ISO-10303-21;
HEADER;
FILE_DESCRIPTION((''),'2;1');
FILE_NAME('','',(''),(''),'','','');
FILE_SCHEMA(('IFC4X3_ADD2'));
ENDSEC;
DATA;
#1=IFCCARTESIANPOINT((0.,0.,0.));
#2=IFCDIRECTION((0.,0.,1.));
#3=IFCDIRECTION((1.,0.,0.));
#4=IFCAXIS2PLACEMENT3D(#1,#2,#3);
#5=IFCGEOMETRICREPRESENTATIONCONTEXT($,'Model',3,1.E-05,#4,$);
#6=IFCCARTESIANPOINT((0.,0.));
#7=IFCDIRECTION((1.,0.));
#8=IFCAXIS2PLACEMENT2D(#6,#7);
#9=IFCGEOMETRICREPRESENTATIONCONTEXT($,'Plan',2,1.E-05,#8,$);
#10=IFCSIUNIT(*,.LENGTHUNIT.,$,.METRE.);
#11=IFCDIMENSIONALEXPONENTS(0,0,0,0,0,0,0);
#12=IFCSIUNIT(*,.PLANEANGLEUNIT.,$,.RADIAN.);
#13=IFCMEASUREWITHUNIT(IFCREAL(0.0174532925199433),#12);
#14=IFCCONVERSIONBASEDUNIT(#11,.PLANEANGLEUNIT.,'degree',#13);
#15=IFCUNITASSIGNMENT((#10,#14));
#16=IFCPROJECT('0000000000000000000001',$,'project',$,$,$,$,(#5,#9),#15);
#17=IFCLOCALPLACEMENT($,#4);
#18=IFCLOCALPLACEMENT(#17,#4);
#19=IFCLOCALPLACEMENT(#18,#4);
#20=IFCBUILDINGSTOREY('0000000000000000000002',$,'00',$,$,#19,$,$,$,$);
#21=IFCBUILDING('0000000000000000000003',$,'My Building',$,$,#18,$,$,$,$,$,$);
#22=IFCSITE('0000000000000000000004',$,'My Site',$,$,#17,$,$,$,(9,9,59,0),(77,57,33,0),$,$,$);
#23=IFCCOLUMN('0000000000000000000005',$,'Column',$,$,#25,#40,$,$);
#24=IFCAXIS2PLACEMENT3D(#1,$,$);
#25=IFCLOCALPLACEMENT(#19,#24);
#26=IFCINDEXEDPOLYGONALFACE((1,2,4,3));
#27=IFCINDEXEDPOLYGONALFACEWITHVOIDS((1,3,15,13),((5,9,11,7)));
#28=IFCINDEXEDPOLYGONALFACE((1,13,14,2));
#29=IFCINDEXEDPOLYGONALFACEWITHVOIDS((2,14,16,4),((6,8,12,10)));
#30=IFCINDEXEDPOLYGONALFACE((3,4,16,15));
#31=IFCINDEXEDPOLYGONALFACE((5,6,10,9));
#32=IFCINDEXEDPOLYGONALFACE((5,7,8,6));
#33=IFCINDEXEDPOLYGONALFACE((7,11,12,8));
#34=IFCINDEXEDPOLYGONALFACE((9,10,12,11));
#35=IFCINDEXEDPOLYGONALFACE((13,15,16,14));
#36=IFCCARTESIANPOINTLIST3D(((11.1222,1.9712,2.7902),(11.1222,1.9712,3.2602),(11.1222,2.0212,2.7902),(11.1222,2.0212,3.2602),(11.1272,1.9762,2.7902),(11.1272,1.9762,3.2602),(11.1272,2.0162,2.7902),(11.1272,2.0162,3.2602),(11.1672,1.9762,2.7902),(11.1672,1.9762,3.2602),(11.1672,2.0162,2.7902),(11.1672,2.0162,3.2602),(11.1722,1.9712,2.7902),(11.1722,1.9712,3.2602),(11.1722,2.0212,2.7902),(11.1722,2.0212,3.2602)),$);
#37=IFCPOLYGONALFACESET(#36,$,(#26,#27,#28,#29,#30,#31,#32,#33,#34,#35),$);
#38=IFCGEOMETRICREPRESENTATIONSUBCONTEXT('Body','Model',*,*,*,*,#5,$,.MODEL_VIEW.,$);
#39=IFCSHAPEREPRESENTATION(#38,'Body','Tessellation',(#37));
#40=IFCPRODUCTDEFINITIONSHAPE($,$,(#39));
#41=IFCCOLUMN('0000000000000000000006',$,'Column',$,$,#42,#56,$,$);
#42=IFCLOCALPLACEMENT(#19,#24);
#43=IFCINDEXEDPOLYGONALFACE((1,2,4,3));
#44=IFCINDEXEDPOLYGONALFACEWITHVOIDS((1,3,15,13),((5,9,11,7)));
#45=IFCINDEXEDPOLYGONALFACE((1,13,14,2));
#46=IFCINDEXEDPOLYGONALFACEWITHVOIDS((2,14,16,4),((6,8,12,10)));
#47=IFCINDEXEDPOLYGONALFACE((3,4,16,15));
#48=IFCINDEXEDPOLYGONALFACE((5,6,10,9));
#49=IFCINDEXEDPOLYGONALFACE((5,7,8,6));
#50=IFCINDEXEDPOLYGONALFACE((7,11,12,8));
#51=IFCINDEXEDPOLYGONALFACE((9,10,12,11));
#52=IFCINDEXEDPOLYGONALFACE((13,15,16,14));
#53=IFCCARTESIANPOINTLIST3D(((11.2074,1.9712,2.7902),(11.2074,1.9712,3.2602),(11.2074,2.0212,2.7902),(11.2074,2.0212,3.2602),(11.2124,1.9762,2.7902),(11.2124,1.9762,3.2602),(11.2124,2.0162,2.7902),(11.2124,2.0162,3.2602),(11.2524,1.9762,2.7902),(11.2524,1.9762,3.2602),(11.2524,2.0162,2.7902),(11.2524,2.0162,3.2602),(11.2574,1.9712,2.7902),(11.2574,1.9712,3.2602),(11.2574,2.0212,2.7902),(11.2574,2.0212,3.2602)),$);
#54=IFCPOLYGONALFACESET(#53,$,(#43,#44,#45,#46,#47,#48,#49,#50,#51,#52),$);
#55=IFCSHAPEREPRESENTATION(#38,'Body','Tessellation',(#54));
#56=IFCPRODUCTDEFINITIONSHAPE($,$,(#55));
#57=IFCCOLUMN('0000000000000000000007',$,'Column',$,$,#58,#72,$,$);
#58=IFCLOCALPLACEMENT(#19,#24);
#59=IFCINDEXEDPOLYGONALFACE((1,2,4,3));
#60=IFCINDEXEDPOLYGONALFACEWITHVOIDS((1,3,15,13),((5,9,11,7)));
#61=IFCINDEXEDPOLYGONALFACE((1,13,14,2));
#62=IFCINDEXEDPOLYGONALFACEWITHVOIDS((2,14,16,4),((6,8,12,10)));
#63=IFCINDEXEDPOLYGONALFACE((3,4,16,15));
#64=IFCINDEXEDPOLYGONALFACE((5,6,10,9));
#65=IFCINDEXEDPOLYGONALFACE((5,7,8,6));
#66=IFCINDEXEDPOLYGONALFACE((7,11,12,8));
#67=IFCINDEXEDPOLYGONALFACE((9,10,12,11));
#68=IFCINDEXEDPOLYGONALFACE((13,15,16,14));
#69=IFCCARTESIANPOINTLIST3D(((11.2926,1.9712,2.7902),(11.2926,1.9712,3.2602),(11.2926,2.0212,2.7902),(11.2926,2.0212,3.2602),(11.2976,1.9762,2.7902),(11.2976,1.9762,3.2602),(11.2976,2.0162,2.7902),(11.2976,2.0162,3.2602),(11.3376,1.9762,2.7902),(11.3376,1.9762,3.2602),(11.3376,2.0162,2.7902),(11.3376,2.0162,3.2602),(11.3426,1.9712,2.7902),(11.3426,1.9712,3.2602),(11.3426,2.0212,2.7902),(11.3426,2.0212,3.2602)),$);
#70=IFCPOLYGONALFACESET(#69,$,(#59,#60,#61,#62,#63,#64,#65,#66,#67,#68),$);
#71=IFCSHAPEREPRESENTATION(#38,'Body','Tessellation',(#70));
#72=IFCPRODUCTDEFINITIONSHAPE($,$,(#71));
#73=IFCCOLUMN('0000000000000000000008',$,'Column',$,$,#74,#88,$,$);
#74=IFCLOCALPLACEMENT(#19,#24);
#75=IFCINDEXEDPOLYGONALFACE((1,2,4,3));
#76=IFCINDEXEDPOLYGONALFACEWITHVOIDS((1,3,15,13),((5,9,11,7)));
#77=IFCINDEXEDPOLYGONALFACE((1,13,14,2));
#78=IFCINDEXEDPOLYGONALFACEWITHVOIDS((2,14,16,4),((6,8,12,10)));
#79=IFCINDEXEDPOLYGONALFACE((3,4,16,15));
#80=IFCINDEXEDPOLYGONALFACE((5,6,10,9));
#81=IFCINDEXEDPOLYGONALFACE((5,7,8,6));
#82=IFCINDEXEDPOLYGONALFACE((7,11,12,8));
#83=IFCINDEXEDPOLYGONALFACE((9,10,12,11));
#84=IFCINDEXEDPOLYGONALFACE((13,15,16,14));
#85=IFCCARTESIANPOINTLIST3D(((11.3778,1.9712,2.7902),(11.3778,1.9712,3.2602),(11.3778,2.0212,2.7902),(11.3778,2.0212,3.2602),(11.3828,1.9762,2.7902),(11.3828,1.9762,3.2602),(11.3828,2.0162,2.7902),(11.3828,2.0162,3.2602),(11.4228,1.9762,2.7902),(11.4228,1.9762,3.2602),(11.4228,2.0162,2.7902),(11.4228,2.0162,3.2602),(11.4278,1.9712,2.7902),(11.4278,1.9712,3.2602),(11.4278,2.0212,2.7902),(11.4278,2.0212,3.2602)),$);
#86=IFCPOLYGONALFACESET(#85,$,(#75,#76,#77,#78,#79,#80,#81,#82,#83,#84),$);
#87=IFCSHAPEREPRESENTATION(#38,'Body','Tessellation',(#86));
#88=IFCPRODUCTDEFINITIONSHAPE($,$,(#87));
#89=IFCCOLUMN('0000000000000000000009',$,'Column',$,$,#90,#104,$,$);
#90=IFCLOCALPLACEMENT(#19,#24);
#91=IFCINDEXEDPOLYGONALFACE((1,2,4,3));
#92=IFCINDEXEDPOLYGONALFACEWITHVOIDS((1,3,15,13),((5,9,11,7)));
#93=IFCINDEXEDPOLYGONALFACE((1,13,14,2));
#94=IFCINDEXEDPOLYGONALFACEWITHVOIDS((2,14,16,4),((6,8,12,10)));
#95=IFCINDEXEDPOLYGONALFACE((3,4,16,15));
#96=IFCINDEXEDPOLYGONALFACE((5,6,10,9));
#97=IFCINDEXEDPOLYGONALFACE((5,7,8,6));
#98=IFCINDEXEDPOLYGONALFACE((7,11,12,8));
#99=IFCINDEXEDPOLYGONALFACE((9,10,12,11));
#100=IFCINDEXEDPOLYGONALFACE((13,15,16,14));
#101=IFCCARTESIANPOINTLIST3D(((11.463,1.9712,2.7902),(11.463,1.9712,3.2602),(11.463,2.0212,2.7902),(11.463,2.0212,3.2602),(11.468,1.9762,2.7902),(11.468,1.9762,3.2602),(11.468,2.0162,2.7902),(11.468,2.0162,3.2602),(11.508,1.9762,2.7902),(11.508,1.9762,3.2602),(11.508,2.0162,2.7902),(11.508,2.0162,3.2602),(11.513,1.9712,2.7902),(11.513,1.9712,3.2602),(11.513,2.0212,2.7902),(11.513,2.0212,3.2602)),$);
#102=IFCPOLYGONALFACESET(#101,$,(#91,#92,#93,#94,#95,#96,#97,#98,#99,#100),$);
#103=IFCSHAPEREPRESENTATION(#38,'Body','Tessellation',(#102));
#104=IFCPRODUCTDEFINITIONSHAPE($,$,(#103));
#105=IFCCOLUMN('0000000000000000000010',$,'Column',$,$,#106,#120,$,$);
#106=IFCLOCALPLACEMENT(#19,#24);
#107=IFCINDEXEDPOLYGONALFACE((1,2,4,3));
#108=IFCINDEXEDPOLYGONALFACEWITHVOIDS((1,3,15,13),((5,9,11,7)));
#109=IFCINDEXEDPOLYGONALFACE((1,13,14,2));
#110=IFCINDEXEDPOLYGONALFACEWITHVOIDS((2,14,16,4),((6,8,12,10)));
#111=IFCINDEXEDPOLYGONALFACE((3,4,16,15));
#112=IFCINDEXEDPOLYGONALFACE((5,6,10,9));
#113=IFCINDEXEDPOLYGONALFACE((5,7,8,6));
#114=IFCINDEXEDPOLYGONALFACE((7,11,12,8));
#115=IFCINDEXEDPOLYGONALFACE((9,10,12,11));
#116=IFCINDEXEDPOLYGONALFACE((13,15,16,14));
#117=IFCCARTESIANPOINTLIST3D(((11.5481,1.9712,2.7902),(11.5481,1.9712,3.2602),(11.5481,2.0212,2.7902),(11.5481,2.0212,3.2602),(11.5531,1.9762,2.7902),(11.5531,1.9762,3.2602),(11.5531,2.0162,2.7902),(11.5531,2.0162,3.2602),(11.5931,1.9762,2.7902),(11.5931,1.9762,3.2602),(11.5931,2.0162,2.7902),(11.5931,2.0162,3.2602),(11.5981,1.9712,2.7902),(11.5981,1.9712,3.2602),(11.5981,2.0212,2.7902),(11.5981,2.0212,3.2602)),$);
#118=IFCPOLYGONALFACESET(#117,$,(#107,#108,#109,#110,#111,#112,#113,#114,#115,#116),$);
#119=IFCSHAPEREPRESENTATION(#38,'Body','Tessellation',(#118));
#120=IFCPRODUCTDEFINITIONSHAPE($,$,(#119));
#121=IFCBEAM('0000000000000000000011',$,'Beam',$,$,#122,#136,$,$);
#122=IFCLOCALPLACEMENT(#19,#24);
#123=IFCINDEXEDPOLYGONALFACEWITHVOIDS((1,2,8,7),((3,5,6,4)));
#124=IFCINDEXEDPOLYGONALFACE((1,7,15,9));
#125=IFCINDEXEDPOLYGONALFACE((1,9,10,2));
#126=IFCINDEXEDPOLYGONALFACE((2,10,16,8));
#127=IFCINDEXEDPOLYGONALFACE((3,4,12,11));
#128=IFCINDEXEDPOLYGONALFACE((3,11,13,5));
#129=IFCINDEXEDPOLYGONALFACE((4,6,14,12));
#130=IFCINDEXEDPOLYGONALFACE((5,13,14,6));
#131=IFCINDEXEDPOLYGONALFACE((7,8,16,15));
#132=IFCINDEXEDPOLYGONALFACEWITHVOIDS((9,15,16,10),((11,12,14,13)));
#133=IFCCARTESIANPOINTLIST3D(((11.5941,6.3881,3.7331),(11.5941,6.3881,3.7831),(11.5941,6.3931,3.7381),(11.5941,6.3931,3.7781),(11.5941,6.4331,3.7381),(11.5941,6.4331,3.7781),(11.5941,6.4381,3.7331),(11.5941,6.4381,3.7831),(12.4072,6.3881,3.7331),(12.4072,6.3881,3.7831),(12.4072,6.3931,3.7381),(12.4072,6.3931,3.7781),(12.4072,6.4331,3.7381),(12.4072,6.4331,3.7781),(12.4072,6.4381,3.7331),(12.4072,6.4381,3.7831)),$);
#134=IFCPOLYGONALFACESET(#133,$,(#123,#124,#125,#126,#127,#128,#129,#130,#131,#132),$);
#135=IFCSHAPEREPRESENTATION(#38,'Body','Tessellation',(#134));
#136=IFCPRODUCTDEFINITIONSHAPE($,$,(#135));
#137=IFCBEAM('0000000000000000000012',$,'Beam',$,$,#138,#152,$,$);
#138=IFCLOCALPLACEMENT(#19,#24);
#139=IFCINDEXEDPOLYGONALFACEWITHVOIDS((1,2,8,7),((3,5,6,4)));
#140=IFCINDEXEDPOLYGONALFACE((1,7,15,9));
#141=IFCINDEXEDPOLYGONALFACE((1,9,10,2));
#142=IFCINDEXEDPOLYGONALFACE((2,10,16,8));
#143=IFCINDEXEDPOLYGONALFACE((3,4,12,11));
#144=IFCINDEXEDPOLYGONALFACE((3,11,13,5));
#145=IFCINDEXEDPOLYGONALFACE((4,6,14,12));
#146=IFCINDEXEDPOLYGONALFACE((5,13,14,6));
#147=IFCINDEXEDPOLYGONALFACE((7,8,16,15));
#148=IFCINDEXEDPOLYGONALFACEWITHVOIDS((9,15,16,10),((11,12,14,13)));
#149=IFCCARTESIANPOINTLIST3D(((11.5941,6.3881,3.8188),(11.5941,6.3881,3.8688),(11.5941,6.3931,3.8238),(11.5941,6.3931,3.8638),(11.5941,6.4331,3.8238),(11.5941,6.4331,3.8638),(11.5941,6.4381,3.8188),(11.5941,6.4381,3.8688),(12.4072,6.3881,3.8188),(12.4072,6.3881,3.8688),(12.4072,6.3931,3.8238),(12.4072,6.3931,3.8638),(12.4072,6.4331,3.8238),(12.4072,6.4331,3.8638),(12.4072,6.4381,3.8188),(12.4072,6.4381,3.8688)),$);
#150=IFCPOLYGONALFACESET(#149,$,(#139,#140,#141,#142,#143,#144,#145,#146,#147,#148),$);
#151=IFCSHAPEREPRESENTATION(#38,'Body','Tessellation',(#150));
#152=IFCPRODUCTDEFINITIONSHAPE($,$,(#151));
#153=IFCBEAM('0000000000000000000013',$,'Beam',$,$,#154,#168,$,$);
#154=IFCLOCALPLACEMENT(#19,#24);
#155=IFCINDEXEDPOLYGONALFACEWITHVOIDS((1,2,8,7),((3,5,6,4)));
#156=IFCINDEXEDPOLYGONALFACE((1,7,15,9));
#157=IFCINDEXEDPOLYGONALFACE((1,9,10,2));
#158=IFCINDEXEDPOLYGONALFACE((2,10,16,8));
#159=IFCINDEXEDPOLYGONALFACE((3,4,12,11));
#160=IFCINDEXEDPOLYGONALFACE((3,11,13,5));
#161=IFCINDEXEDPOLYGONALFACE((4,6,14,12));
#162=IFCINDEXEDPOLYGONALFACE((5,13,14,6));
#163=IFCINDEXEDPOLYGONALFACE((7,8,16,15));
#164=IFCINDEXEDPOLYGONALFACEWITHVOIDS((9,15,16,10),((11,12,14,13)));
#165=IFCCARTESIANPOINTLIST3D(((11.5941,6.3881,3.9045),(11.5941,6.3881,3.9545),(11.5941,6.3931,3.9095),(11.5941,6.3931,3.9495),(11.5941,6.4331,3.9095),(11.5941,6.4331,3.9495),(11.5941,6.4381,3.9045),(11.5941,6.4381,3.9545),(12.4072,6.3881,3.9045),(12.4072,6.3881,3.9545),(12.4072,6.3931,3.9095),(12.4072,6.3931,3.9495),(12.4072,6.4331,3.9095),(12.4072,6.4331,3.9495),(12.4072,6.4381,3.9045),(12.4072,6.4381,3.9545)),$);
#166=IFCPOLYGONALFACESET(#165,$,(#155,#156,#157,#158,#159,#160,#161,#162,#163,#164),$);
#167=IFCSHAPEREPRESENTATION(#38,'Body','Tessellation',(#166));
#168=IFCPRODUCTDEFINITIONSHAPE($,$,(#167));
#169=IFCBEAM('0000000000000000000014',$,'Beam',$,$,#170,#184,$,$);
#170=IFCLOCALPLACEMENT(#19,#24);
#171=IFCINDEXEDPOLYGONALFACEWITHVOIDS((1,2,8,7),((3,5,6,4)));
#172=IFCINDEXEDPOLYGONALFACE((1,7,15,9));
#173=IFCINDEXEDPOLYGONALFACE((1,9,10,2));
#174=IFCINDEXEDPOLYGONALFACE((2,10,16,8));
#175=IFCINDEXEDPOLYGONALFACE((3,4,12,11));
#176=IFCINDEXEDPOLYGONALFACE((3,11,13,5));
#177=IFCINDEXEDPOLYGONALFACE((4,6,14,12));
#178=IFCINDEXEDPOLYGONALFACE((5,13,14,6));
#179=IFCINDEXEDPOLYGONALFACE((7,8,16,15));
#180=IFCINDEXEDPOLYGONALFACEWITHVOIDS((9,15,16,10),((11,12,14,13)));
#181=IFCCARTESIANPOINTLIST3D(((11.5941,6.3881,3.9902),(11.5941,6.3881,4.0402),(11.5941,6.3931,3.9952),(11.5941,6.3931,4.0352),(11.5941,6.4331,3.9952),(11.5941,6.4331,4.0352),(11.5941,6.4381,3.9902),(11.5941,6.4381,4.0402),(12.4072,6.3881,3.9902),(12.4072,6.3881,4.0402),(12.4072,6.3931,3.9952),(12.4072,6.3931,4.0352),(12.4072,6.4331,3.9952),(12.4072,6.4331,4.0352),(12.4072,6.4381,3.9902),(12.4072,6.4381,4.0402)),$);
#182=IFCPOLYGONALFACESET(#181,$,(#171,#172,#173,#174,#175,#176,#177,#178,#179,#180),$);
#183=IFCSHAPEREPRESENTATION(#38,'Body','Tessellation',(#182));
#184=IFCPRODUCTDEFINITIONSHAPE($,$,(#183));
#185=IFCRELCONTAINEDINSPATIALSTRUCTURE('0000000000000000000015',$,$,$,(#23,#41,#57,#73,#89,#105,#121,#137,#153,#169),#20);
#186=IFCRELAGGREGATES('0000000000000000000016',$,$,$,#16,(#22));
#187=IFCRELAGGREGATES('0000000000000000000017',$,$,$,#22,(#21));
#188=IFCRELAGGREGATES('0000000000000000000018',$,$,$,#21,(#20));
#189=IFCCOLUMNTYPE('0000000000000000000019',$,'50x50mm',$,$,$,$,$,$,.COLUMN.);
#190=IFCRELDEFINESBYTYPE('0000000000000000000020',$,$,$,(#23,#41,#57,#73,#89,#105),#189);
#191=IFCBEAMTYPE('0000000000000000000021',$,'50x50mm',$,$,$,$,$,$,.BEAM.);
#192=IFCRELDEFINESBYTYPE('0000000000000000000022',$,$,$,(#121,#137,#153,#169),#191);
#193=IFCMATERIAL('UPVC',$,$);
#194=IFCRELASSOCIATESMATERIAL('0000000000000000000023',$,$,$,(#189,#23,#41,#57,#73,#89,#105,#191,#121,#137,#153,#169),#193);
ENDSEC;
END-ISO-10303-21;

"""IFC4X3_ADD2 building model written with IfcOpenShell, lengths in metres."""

from ifc_helpers import new_model, entity, si_unit, converted_unit, frame, origin_with_axes, origin_2d_with_axis, place, context, subcontext, project, spatial, hollow_rectangle, extrude, material, material_profile, profile_set, profile_usage, type_object, element, save


model = new_model("IFC4X3_ADD2")

# Units and contexts
model_context = context("Model", 3, precision=1e-05, world=origin_with_axes())
plan_context = context("Plan", 2, precision=1e-05, world=origin_2d_with_axis())
body_context = subcontext(model_context, "Body", "Model", "MODEL_VIEW")
ifc_project = project(units=[si_unit("LENGTHUNIT", "METRE"), converted_unit("PLANEANGLEUNIT", "degree", entity("IfcReal", 0.0174532925199433), si_unit("PLANEANGLEUNIT", "RADIAN"), dimensions=[0, 0, 0, 0, 0, 0, 0])], contexts=[model_context, plan_context])

# Site, building, storey
site_placement = place(None, origin_with_axes())
site = spatial("IfcSite", under=ifc_project, at=site_placement, Name="My Site", RefLatitude=(9, 9, 59, 0), RefLongitude=(77, 57, 33, 0))
building_placement = place(site_placement, origin_with_axes())
building = spatial("IfcBuilding", under=site, at=building_placement, Name="My Building")
storey_placement = place(building_placement, origin_with_axes())
storey = spatial("IfcBuildingStorey", under=building, at=storey_placement, Name="00")

# Columns
ifc_material_1 = material(Name="UPVC")
ifc_material_profile_1 = material_profile(ifc_material_1, hollow_rectangle(XDim=0.05, YDim=0.05, WallThickness=0.005))
ifc_profile_set_1 = profile_set([ifc_material_profile_1])
column_type = type_object("IfcColumnType", Name="50x50mm", PredefinedType="COLUMN", material=ifc_profile_set_1)
ifc_profile_usage_1 = profile_usage(ifc_profile_set_1, cardinal=5)
column_1_placement = place(storey_placement, frame((11.1472, 1.9962, 2.7902), z_axis=(0.0, 0.0, 1.0), x_axis=(1.0, 0.0, 0.0)))
element("IfcColumn", 1, at=column_1_placement, inside=storey, type_object=column_type, material=ifc_profile_usage_1, Name="Column", context=body_context, shape_type="SweptSolid", body=[
    extrude(hollow_rectangle(XDim=0.05, YDim=0.05, WallThickness=0.005), origin_with_axes(), (0.0, 0.0, 1.0), 0.47),
])
ifc_profile_usage_2 = profile_usage(ifc_profile_set_1, cardinal=5)
column_2_placement = place(storey_placement, frame((11.2324, 1.9962, 2.7902), z_axis=(0.0, 0.0, 1.0), x_axis=(1.0, 0.0, 0.0)))
element("IfcColumn", 2, at=column_2_placement, inside=storey, type_object=column_type, material=ifc_profile_usage_2, Name="Column", context=body_context, shape_type="SweptSolid", body=[
    extrude(hollow_rectangle(XDim=0.05, YDim=0.05, WallThickness=0.005), origin_with_axes(), (0.0, 0.0, 1.0), 0.47),
])
ifc_profile_usage_3 = profile_usage(ifc_profile_set_1, cardinal=5)
column_3_placement = place(storey_placement, frame((11.3176, 1.9962, 2.7902), z_axis=(0.0, 0.0, 1.0), x_axis=(1.0, 0.0, 0.0)))
element("IfcColumn", 3, at=column_3_placement, inside=storey, type_object=column_type, material=ifc_profile_usage_3, Name="Column", context=body_context, shape_type="SweptSolid", body=[
    extrude(hollow_rectangle(XDim=0.05, YDim=0.05, WallThickness=0.005), origin_with_axes(), (0.0, 0.0, 1.0), 0.47),
])
ifc_profile_usage_4 = profile_usage(ifc_profile_set_1, cardinal=5)
column_4_placement = place(storey_placement, frame((11.4028, 1.9962, 2.7902), z_axis=(0.0, 0.0, 1.0), x_axis=(1.0, 0.0, 0.0)))
element("IfcColumn", 4, at=column_4_placement, inside=storey, type_object=column_type, material=ifc_profile_usage_4, Name="Column", context=body_context, shape_type="SweptSolid", body=[
    extrude(hollow_rectangle(XDim=0.05, YDim=0.05, WallThickness=0.005), origin_with_axes(), (0.0, 0.0, 1.0), 0.47),
])
ifc_profile_usage_5 = profile_usage(ifc_profile_set_1, cardinal=5)
column_5_placement = place(storey_placement, frame((11.488, 1.9962, 2.7902), z_axis=(0.0, 0.0, 1.0), x_axis=(1.0, 0.0, 0.0)))
element("IfcColumn", 5, at=column_5_placement, inside=storey, type_object=column_type, material=ifc_profile_usage_5, Name="Column", context=body_context, shape_type="SweptSolid", body=[
    extrude(hollow_rectangle(XDim=0.05, YDim=0.05, WallThickness=0.005), origin_with_axes(), (0.0, 0.0, 1.0), 0.47),
])
ifc_profile_usage_6 = profile_usage(ifc_profile_set_1, cardinal=5)
column_6_placement = place(storey_placement, frame((11.5731, 1.9962, 2.7902), z_axis=(0.0, 0.0, 1.0), x_axis=(1.0, 0.0, 0.0)))
element("IfcColumn", 6, at=column_6_placement, inside=storey, type_object=column_type, material=ifc_profile_usage_6, Name="Column", context=body_context, shape_type="SweptSolid", body=[
    extrude(hollow_rectangle(XDim=0.05, YDim=0.05, WallThickness=0.005), origin_with_axes(), (0.0, 0.0, 1.0), 0.47),
])

# Beams
ifc_material_profile_2 = material_profile(ifc_material_1, hollow_rectangle(XDim=0.05, YDim=0.05, WallThickness=0.005))
ifc_profile_set_2 = profile_set([ifc_material_profile_2])
ifc_profile_usage_7 = profile_usage(ifc_profile_set_2, cardinal=5)
beam_type = type_object("IfcBeamType", Name="50x50mm", PredefinedType="BEAM", material=ifc_profile_set_2)
beam_1_placement = place(storey_placement, frame((11.5941, 6.4131, 3.7581), z_axis=(1.0, 0.0, 0.000001), x_axis=(0.0, 1.0, 0.0)))
element("IfcBeam", 7, at=beam_1_placement, inside=storey, type_object=beam_type, material=ifc_profile_usage_7, Name="Beam", context=body_context, shape_type="SweptSolid", body=[
    extrude(hollow_rectangle(XDim=0.05, YDim=0.05, WallThickness=0.005), origin_with_axes(), (0.0, 0.0, 1.0), 0.8131),
])
ifc_profile_usage_8 = profile_usage(ifc_profile_set_2, cardinal=5)
beam_2_placement = place(storey_placement, frame((11.5941, 6.4131, 3.8438), z_axis=(1.0, 0.0, 0.000001), x_axis=(0.0, 1.0, 0.0)))
element("IfcBeam", 8, at=beam_2_placement, inside=storey, type_object=beam_type, material=ifc_profile_usage_8, Name="Beam", context=body_context, shape_type="SweptSolid", body=[
    extrude(hollow_rectangle(XDim=0.05, YDim=0.05, WallThickness=0.005), origin_with_axes(), (0.0, 0.0, 1.0), 0.8131),
])
ifc_profile_usage_9 = profile_usage(ifc_profile_set_2, cardinal=5)
beam_3_placement = place(storey_placement, frame((11.5941, 6.4131, 3.9295), z_axis=(1.0, 0.0, 0.000001), x_axis=(0.0, 1.0, 0.0)))
element("IfcBeam", 9, at=beam_3_placement, inside=storey, type_object=beam_type, material=ifc_profile_usage_9, Name="Beam", context=body_context, shape_type="SweptSolid", body=[
    extrude(hollow_rectangle(XDim=0.05, YDim=0.05, WallThickness=0.005), origin_with_axes(), (0.0, 0.0, 1.0), 0.8131),
])
ifc_profile_usage_10 = profile_usage(ifc_profile_set_2, cardinal=5)
beam_4_placement = place(storey_placement, frame((11.5941, 6.4131, 4.0152), z_axis=(1.0, 0.0, 0.000001), x_axis=(0.0, 1.0, 0.0)))
element("IfcBeam", 10, at=beam_4_placement, inside=storey, type_object=beam_type, material=ifc_profile_usage_10, Name="Beam", context=body_context, shape_type="SweptSolid", body=[
    extrude(hollow_rectangle(XDim=0.05, YDim=0.05, WallThickness=0.005), origin_with_axes(), (0.0, 0.0, 1.0), 0.8131),
])

save(model, "model.ifc")
